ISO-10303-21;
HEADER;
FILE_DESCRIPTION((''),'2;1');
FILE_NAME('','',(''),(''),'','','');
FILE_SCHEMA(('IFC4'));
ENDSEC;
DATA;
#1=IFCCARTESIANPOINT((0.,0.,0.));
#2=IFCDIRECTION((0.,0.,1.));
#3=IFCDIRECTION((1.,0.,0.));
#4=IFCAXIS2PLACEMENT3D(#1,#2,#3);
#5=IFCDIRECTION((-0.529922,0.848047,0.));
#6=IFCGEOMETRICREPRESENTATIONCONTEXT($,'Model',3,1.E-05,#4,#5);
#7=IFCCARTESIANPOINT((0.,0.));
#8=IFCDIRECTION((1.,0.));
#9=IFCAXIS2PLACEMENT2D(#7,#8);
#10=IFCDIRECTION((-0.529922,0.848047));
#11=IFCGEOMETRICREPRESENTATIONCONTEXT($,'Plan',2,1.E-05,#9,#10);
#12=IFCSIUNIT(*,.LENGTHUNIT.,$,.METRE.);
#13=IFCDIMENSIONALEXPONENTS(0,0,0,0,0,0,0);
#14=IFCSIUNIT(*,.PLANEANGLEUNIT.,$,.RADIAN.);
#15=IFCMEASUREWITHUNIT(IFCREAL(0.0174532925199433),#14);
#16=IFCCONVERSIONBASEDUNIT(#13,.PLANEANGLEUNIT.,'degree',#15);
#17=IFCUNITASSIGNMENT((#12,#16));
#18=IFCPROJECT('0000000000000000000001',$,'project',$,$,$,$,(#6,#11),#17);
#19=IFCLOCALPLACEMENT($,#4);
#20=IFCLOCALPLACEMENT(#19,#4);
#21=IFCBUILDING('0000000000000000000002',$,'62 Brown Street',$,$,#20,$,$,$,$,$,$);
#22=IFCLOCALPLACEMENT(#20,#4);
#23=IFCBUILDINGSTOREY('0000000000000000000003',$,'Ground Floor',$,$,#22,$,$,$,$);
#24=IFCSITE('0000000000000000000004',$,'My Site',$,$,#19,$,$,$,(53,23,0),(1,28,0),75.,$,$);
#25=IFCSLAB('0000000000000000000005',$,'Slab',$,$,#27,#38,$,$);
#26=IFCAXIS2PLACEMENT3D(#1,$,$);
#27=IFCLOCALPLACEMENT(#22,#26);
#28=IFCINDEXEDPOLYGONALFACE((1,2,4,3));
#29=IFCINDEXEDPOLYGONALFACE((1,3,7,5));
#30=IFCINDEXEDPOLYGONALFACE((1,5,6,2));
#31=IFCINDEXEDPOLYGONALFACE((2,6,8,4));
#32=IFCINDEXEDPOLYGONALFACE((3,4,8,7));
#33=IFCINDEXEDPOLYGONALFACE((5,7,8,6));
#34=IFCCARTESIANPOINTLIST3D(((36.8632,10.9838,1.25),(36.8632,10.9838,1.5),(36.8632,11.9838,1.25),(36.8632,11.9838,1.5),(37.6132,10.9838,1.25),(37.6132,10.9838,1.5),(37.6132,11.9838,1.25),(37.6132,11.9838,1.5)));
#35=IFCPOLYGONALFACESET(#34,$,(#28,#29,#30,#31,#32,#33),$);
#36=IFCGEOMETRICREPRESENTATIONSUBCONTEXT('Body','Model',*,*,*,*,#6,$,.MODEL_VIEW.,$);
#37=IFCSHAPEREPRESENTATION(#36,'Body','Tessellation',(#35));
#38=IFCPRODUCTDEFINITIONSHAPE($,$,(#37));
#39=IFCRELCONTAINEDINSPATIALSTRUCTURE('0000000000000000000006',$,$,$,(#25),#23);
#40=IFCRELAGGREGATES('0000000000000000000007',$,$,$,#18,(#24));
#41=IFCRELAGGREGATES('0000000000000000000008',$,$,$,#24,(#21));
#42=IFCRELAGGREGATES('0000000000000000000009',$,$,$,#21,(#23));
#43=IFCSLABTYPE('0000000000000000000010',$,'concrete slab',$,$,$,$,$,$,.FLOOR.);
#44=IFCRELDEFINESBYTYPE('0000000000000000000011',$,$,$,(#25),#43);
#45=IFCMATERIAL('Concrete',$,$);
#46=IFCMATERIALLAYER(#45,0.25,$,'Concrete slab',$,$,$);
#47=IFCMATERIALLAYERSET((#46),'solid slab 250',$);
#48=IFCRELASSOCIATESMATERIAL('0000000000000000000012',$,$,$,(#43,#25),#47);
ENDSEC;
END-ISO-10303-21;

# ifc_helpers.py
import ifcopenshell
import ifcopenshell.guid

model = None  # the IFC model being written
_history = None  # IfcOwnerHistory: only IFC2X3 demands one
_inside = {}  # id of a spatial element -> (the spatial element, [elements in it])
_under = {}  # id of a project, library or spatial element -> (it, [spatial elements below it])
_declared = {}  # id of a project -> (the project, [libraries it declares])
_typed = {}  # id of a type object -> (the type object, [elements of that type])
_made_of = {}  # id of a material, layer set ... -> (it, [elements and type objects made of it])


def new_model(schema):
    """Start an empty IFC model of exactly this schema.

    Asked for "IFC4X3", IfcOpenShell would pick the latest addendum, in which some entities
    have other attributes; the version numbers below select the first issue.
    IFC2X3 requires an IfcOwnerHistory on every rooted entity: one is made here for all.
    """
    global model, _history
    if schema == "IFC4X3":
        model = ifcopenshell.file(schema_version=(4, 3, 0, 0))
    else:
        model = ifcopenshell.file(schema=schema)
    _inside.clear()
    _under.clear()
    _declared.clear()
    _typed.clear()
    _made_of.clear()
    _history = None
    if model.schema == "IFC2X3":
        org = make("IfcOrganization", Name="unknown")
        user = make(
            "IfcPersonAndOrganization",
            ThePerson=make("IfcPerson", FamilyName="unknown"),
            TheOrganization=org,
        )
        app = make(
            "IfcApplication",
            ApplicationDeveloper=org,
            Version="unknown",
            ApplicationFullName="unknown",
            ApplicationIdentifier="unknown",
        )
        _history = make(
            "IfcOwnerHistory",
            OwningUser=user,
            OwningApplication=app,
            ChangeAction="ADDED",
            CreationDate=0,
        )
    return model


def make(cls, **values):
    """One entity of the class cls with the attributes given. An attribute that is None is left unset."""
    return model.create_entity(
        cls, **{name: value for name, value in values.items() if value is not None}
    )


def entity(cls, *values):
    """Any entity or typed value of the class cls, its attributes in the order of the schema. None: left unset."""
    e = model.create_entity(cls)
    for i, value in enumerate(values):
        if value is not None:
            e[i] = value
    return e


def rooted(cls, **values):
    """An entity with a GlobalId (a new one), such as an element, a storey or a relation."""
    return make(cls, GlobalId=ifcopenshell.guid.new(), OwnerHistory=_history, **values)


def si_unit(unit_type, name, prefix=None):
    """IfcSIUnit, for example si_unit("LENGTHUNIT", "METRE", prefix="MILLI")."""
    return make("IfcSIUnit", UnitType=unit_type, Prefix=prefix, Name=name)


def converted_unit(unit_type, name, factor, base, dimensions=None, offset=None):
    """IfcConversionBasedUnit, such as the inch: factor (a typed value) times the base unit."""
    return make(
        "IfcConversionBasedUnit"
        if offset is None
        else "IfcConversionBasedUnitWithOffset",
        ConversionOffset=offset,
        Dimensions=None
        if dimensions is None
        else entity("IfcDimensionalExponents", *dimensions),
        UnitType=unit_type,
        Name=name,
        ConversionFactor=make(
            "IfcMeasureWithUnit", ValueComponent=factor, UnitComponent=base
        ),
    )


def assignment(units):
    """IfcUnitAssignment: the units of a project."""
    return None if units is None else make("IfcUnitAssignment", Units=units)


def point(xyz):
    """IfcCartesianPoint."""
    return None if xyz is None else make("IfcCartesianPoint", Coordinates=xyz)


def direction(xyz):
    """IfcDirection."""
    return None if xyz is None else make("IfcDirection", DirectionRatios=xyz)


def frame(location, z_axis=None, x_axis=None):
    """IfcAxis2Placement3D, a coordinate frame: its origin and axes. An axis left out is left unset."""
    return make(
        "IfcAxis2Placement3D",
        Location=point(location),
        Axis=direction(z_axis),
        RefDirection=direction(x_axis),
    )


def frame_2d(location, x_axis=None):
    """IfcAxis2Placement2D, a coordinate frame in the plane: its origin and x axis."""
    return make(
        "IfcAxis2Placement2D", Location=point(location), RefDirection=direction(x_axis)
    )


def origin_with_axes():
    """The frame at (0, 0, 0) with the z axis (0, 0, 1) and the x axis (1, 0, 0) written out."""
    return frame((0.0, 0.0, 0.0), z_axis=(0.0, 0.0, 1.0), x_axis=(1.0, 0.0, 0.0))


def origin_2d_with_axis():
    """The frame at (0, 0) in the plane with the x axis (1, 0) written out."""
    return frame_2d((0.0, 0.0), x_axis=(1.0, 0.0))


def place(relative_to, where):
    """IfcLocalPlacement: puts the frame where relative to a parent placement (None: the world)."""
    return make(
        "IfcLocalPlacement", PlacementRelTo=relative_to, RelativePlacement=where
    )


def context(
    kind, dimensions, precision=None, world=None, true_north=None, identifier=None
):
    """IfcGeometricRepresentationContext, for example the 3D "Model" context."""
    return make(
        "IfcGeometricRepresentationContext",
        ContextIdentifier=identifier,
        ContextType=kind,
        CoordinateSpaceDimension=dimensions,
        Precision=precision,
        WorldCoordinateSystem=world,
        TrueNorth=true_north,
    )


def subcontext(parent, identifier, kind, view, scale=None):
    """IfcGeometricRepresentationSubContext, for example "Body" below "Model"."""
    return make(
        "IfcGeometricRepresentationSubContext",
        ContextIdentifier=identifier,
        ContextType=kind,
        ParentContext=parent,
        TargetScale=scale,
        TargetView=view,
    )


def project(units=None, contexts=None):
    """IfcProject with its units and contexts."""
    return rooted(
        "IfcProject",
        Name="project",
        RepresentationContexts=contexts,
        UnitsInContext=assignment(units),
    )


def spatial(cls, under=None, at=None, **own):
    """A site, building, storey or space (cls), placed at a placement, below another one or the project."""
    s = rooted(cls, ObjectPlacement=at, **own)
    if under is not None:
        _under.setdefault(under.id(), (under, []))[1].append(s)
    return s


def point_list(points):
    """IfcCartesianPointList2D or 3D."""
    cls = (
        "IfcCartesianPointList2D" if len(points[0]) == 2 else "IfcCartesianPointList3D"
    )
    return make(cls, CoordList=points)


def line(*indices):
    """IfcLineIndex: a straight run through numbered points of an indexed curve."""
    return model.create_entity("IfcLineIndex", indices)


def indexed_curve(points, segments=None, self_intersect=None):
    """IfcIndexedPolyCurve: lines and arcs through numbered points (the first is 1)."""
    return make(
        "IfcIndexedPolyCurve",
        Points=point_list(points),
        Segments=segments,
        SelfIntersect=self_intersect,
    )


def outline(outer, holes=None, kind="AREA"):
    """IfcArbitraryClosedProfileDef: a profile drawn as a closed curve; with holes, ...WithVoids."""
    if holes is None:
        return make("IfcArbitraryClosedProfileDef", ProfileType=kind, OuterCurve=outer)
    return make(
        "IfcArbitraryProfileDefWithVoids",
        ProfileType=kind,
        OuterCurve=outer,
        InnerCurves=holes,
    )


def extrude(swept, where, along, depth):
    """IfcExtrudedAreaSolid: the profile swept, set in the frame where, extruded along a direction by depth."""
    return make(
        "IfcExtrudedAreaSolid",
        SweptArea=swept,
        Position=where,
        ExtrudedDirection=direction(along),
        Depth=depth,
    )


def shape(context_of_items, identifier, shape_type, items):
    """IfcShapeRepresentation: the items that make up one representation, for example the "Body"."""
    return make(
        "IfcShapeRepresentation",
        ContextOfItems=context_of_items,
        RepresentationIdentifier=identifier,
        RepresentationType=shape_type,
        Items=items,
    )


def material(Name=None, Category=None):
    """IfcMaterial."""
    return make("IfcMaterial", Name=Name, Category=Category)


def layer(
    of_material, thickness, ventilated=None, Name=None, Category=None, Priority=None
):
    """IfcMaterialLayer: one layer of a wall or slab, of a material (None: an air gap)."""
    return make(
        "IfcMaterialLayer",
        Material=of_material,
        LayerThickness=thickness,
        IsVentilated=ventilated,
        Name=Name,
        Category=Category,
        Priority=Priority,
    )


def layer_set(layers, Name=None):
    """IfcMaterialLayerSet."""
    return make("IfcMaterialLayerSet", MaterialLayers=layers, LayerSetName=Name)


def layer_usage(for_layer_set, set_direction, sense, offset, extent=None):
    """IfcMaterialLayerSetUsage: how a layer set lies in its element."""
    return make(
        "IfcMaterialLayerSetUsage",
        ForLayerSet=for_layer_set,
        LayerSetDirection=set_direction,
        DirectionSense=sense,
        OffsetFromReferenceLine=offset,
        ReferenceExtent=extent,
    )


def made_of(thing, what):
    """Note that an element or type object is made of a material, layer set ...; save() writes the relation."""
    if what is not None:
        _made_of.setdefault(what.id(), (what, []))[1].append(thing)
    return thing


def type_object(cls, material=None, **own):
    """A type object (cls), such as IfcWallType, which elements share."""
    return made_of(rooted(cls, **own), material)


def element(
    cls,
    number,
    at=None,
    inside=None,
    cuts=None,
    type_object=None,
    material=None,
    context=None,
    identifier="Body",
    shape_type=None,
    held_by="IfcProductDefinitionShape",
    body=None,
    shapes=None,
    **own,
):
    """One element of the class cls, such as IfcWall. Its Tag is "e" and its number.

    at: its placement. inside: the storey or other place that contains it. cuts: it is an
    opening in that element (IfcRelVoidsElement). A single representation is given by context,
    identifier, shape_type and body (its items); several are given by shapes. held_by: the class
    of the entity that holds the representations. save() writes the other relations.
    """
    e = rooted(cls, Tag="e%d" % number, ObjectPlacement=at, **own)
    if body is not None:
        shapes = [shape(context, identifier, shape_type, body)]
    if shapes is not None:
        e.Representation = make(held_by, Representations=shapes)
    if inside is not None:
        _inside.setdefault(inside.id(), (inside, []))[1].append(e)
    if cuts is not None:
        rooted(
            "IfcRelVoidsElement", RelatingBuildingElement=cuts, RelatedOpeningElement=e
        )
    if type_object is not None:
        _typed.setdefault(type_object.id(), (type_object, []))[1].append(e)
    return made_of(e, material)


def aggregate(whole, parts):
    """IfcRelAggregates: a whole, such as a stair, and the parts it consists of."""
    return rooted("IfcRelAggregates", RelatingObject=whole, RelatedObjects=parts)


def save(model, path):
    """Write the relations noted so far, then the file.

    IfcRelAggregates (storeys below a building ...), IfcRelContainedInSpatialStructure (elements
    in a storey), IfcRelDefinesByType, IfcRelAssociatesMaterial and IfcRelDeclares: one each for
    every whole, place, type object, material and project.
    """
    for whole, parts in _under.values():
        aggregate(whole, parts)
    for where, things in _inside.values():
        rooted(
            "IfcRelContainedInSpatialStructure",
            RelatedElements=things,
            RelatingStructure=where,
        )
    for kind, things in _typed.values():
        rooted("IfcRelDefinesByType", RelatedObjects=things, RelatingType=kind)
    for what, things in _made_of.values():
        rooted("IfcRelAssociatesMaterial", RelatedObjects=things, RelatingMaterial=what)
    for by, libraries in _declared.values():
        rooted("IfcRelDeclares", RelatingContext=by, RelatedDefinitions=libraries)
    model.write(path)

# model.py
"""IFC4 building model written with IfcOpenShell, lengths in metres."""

from ifc_helpers import new_model, entity, si_unit, converted_unit, direction, frame, origin_with_axes, origin_2d_with_axis, place, context, subcontext, project, spatial, line, indexed_curve, outline, extrude, material, layer, layer_set, layer_usage, type_object, element, save


model = new_model("IFC4")

# Units and contexts
model_context = context("Model", 3, precision=1e-05, world=origin_with_axes(), true_north=direction((-0.529922, 0.848047, 0.0)))
plan_context = context("Plan", 2, precision=1e-05, world=origin_2d_with_axis(), true_north=direction((-0.529922, 0.848047)))
body_context_1 = subcontext(model_context, "Body", "Model", "MODEL_VIEW")
ifc_project = project(units=[si_unit("LENGTHUNIT", "METRE"), converted_unit("PLANEANGLEUNIT", "degree", entity("IfcReal", 0.0174532925199433), si_unit("PLANEANGLEUNIT", "RADIAN"), dimensions=[0, 0, 0, 0, 0, 0, 0])], contexts=[model_context, plan_context])

# Site, building, storey
site_placement = place(None, origin_with_axes())
site = spatial("IfcSite", under=ifc_project, at=site_placement, Name="My Site", RefLatitude=(53, 23, 0), RefLongitude=(1, 28, 0), RefElevation=75.0)
building_placement = place(site_placement, origin_with_axes())
building = spatial("IfcBuilding", under=site, at=building_placement, Name="62 Brown Street")
storey_placement = place(building_placement, origin_with_axes())
storey = spatial("IfcBuildingStorey", under=building, at=storey_placement, Name="Ground Floor")

# Slab
ifc_material_1 = material(Name="Concrete")
ifc_layer_1 = layer(ifc_material_1, 0.25, Name="Concrete slab")
ifc_layer_set_1 = layer_set([ifc_layer_1], Name="solid slab 250")
ifc_layer_usage_1 = layer_usage(ifc_layer_set_1, "AXIS3", "POSITIVE", 0.0)
slab_type = type_object("IfcSlabType", Name="concrete slab", PredefinedType="FLOOR", material=ifc_layer_set_1)
slab_placement = place(storey_placement, frame((36.8632, 10.9838, 1.25), z_axis=(0.0, 0.0, 1.0), x_axis=(1.0, 0.0, 0.0)))
element("IfcSlab", 1, at=slab_placement, inside=storey, type_object=slab_type, material=ifc_layer_usage_1, Name="Slab", context=body_context_1, shape_type="SweptSolid", body=[
    extrude(outline(indexed_curve([(0.0, 0.0), (0.75, 0.0), (0.75, 1.0), (0.0, 1.0)], segments=[line(4, 1), line(1, 2), line(2, 3), line(3, 4)], self_intersect=False)), None, (0.0, 0.0, 1.0), 0.25),
])

save(model, "model.ifc")
